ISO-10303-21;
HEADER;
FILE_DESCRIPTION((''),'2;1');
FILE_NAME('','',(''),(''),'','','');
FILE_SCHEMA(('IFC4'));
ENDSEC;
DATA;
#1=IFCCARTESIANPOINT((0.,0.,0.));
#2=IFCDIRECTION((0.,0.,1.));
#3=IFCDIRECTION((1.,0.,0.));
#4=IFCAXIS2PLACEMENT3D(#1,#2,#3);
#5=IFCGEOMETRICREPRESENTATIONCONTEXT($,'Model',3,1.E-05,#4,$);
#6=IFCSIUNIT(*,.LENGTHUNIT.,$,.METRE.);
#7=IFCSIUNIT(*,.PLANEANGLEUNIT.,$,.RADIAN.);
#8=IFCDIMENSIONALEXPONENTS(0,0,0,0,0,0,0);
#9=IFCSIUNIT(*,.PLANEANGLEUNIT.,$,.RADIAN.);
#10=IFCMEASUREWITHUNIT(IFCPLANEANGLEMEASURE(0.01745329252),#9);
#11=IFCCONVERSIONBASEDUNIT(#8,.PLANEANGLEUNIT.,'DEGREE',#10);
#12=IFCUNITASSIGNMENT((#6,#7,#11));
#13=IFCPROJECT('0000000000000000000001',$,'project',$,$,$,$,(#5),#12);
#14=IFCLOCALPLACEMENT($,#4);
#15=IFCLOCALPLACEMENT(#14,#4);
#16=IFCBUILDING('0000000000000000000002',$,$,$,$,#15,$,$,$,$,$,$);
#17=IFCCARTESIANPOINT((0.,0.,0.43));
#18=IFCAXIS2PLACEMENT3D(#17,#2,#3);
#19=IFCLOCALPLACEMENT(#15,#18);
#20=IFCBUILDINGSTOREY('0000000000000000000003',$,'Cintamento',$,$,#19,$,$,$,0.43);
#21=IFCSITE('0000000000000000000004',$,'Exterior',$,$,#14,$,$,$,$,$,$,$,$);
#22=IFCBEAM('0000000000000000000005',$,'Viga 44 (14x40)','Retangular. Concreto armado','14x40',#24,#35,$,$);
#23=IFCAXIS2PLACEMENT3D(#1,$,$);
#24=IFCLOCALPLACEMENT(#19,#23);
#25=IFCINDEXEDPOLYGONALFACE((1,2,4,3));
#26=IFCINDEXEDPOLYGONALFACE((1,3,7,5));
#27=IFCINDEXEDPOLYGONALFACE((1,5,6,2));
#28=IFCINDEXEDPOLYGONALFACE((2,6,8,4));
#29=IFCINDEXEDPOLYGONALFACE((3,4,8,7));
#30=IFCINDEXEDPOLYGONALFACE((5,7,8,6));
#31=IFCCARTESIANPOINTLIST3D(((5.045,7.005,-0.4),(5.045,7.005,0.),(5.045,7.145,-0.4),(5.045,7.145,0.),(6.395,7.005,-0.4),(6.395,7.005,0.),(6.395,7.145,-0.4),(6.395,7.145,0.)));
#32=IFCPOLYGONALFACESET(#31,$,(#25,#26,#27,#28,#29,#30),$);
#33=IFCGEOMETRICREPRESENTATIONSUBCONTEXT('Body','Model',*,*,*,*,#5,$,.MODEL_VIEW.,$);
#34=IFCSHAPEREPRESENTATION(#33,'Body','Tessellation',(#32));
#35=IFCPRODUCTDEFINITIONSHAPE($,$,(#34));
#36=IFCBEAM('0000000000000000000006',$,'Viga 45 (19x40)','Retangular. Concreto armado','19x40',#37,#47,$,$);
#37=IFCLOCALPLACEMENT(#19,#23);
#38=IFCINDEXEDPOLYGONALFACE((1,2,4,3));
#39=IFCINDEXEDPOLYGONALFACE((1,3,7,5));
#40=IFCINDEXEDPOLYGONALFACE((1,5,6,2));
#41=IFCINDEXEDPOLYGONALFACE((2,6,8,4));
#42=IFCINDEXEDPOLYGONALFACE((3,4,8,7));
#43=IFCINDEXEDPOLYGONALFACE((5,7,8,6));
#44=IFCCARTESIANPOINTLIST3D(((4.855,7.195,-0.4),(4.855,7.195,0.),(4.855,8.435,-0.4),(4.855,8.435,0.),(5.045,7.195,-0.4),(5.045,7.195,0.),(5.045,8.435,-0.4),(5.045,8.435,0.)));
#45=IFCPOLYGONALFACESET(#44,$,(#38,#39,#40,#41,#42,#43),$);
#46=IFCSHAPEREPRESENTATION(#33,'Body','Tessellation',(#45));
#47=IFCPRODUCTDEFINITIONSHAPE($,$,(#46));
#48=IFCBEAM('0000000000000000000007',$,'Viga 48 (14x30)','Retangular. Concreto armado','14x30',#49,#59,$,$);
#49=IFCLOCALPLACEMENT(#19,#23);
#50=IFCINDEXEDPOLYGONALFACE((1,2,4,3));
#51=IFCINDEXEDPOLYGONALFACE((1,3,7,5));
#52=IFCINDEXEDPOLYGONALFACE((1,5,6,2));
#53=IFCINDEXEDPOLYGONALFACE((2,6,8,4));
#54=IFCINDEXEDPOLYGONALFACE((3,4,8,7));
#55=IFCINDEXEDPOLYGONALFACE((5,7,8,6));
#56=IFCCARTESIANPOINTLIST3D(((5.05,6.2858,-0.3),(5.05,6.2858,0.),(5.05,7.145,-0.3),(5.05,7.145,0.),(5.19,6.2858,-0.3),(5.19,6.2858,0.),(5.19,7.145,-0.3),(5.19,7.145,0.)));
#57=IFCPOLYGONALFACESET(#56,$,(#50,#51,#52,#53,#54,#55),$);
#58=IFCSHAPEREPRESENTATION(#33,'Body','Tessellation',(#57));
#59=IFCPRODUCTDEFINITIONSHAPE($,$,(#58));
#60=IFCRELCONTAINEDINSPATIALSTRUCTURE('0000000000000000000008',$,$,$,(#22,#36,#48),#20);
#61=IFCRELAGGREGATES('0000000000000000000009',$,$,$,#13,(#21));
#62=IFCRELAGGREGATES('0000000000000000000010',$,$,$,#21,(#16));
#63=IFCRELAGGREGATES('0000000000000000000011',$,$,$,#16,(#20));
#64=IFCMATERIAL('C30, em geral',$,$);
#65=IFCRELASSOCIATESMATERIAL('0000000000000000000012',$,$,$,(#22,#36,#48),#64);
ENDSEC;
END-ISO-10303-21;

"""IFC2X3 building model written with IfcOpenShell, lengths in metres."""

from ifc_helpers import new_model, entity, si_unit, converted_unit, frame, frame_2d, origin_with_axes, place, context, subcontext, project, spatial, rectangle, extrude, material, element, save


model = new_model("IFC2X3")

# Units and contexts
model_context = context("Model", 3, precision=1e-05, world=origin_with_axes())
body_context = subcontext(model_context, "Body", "Model", "MODEL_VIEW")
ifc_project = project(units=[si_unit("LENGTHUNIT", "METRE"), si_unit("PLANEANGLEUNIT", "RADIAN"), converted_unit("PLANEANGLEUNIT", "DEGREE", entity("IfcPlaneAngleMeasure", 0.01745329252), si_unit("PLANEANGLEUNIT", "RADIAN"), dimensions=[0, 0, 0, 0, 0, 0, 0])], contexts=[model_context])

# Site, building, storey
site_placement = place(None, origin_with_axes())
site = spatial("IfcSite", under=ifc_project, at=site_placement, Name="Exterior")
building_placement = place(site_placement, origin_with_axes())
building = spatial("IfcBuilding", under=site, at=building_placement)
storey_placement = place(building_placement, frame((0.0, 0.0, 0.43), z_axis=(0.0, 0.0, 1.0), x_axis=(1.0, 0.0, 0.0)))
storey = spatial("IfcBuildingStorey", under=building, at=storey_placement, Name="Cintamento", Elevation=0.43)

# Beams
ifc_material_1 = material(Name="C30, em geral")
beam_1_placement = place(storey_placement, frame((5.045, 7.075, 0.0), z_axis=(1.0, 0.0, 0.0), x_axis=(0.0, 1.0, 0.0)))
element("IfcBeam", 1, at=beam_1_placement, inside=storey, material=ifc_material_1, Name="Viga 44 (14x40)", Description="Retangular. Concreto armado", ObjectType="14x40", context=body_context, shape_type="SweptSolid", body=[
    extrude(rectangle(XDim=0.14, YDim=0.4, at=frame_2d((0.0, -0.2), x_axis=(1.0, 0.0))), origin_with_axes(), (0.0, 0.0, 1.0), 1.35),
])
beam_2_placement = place(storey_placement, frame((4.95, 7.195, 0.0), z_axis=(0.0, 1.0, 0.0), x_axis=(-1.0, 0.0, 0.0)))
element("IfcBeam", 2, at=beam_2_placement, inside=storey, material=ifc_material_1, Name="Viga 45 (19x40)", Description="Retangular. Concreto armado", ObjectType="19x40", context=body_context, shape_type="SweptSolid", body=[
    extrude(rectangle(XDim=0.19, YDim=0.4, at=frame_2d((0.0, -0.2), x_axis=(1.0, 0.0))), origin_with_axes(), (0.0, 0.0, 1.0), 1.24),
])
beam_3_placement = place(storey_placement, frame((5.12, 6.2858, 0.0), z_axis=(0.0, 1.0, 0.0), x_axis=(-1.0, 0.0, 0.0)))
element("IfcBeam", 3, at=beam_3_placement, inside=storey, material=ifc_material_1, Name="Viga 48 (14x30)", Description="Retangular. Concreto armado", ObjectType="14x30", context=body_context, shape_type="SweptSolid", body=[
    extrude(rectangle(XDim=0.14, YDim=0.3, at=frame_2d((0.0, -0.15), x_axis=(1.0, 0.0))), origin_with_axes(), (0.0, 0.0, 1.0), 0.8592),
])

save(model, "model.ifc")
